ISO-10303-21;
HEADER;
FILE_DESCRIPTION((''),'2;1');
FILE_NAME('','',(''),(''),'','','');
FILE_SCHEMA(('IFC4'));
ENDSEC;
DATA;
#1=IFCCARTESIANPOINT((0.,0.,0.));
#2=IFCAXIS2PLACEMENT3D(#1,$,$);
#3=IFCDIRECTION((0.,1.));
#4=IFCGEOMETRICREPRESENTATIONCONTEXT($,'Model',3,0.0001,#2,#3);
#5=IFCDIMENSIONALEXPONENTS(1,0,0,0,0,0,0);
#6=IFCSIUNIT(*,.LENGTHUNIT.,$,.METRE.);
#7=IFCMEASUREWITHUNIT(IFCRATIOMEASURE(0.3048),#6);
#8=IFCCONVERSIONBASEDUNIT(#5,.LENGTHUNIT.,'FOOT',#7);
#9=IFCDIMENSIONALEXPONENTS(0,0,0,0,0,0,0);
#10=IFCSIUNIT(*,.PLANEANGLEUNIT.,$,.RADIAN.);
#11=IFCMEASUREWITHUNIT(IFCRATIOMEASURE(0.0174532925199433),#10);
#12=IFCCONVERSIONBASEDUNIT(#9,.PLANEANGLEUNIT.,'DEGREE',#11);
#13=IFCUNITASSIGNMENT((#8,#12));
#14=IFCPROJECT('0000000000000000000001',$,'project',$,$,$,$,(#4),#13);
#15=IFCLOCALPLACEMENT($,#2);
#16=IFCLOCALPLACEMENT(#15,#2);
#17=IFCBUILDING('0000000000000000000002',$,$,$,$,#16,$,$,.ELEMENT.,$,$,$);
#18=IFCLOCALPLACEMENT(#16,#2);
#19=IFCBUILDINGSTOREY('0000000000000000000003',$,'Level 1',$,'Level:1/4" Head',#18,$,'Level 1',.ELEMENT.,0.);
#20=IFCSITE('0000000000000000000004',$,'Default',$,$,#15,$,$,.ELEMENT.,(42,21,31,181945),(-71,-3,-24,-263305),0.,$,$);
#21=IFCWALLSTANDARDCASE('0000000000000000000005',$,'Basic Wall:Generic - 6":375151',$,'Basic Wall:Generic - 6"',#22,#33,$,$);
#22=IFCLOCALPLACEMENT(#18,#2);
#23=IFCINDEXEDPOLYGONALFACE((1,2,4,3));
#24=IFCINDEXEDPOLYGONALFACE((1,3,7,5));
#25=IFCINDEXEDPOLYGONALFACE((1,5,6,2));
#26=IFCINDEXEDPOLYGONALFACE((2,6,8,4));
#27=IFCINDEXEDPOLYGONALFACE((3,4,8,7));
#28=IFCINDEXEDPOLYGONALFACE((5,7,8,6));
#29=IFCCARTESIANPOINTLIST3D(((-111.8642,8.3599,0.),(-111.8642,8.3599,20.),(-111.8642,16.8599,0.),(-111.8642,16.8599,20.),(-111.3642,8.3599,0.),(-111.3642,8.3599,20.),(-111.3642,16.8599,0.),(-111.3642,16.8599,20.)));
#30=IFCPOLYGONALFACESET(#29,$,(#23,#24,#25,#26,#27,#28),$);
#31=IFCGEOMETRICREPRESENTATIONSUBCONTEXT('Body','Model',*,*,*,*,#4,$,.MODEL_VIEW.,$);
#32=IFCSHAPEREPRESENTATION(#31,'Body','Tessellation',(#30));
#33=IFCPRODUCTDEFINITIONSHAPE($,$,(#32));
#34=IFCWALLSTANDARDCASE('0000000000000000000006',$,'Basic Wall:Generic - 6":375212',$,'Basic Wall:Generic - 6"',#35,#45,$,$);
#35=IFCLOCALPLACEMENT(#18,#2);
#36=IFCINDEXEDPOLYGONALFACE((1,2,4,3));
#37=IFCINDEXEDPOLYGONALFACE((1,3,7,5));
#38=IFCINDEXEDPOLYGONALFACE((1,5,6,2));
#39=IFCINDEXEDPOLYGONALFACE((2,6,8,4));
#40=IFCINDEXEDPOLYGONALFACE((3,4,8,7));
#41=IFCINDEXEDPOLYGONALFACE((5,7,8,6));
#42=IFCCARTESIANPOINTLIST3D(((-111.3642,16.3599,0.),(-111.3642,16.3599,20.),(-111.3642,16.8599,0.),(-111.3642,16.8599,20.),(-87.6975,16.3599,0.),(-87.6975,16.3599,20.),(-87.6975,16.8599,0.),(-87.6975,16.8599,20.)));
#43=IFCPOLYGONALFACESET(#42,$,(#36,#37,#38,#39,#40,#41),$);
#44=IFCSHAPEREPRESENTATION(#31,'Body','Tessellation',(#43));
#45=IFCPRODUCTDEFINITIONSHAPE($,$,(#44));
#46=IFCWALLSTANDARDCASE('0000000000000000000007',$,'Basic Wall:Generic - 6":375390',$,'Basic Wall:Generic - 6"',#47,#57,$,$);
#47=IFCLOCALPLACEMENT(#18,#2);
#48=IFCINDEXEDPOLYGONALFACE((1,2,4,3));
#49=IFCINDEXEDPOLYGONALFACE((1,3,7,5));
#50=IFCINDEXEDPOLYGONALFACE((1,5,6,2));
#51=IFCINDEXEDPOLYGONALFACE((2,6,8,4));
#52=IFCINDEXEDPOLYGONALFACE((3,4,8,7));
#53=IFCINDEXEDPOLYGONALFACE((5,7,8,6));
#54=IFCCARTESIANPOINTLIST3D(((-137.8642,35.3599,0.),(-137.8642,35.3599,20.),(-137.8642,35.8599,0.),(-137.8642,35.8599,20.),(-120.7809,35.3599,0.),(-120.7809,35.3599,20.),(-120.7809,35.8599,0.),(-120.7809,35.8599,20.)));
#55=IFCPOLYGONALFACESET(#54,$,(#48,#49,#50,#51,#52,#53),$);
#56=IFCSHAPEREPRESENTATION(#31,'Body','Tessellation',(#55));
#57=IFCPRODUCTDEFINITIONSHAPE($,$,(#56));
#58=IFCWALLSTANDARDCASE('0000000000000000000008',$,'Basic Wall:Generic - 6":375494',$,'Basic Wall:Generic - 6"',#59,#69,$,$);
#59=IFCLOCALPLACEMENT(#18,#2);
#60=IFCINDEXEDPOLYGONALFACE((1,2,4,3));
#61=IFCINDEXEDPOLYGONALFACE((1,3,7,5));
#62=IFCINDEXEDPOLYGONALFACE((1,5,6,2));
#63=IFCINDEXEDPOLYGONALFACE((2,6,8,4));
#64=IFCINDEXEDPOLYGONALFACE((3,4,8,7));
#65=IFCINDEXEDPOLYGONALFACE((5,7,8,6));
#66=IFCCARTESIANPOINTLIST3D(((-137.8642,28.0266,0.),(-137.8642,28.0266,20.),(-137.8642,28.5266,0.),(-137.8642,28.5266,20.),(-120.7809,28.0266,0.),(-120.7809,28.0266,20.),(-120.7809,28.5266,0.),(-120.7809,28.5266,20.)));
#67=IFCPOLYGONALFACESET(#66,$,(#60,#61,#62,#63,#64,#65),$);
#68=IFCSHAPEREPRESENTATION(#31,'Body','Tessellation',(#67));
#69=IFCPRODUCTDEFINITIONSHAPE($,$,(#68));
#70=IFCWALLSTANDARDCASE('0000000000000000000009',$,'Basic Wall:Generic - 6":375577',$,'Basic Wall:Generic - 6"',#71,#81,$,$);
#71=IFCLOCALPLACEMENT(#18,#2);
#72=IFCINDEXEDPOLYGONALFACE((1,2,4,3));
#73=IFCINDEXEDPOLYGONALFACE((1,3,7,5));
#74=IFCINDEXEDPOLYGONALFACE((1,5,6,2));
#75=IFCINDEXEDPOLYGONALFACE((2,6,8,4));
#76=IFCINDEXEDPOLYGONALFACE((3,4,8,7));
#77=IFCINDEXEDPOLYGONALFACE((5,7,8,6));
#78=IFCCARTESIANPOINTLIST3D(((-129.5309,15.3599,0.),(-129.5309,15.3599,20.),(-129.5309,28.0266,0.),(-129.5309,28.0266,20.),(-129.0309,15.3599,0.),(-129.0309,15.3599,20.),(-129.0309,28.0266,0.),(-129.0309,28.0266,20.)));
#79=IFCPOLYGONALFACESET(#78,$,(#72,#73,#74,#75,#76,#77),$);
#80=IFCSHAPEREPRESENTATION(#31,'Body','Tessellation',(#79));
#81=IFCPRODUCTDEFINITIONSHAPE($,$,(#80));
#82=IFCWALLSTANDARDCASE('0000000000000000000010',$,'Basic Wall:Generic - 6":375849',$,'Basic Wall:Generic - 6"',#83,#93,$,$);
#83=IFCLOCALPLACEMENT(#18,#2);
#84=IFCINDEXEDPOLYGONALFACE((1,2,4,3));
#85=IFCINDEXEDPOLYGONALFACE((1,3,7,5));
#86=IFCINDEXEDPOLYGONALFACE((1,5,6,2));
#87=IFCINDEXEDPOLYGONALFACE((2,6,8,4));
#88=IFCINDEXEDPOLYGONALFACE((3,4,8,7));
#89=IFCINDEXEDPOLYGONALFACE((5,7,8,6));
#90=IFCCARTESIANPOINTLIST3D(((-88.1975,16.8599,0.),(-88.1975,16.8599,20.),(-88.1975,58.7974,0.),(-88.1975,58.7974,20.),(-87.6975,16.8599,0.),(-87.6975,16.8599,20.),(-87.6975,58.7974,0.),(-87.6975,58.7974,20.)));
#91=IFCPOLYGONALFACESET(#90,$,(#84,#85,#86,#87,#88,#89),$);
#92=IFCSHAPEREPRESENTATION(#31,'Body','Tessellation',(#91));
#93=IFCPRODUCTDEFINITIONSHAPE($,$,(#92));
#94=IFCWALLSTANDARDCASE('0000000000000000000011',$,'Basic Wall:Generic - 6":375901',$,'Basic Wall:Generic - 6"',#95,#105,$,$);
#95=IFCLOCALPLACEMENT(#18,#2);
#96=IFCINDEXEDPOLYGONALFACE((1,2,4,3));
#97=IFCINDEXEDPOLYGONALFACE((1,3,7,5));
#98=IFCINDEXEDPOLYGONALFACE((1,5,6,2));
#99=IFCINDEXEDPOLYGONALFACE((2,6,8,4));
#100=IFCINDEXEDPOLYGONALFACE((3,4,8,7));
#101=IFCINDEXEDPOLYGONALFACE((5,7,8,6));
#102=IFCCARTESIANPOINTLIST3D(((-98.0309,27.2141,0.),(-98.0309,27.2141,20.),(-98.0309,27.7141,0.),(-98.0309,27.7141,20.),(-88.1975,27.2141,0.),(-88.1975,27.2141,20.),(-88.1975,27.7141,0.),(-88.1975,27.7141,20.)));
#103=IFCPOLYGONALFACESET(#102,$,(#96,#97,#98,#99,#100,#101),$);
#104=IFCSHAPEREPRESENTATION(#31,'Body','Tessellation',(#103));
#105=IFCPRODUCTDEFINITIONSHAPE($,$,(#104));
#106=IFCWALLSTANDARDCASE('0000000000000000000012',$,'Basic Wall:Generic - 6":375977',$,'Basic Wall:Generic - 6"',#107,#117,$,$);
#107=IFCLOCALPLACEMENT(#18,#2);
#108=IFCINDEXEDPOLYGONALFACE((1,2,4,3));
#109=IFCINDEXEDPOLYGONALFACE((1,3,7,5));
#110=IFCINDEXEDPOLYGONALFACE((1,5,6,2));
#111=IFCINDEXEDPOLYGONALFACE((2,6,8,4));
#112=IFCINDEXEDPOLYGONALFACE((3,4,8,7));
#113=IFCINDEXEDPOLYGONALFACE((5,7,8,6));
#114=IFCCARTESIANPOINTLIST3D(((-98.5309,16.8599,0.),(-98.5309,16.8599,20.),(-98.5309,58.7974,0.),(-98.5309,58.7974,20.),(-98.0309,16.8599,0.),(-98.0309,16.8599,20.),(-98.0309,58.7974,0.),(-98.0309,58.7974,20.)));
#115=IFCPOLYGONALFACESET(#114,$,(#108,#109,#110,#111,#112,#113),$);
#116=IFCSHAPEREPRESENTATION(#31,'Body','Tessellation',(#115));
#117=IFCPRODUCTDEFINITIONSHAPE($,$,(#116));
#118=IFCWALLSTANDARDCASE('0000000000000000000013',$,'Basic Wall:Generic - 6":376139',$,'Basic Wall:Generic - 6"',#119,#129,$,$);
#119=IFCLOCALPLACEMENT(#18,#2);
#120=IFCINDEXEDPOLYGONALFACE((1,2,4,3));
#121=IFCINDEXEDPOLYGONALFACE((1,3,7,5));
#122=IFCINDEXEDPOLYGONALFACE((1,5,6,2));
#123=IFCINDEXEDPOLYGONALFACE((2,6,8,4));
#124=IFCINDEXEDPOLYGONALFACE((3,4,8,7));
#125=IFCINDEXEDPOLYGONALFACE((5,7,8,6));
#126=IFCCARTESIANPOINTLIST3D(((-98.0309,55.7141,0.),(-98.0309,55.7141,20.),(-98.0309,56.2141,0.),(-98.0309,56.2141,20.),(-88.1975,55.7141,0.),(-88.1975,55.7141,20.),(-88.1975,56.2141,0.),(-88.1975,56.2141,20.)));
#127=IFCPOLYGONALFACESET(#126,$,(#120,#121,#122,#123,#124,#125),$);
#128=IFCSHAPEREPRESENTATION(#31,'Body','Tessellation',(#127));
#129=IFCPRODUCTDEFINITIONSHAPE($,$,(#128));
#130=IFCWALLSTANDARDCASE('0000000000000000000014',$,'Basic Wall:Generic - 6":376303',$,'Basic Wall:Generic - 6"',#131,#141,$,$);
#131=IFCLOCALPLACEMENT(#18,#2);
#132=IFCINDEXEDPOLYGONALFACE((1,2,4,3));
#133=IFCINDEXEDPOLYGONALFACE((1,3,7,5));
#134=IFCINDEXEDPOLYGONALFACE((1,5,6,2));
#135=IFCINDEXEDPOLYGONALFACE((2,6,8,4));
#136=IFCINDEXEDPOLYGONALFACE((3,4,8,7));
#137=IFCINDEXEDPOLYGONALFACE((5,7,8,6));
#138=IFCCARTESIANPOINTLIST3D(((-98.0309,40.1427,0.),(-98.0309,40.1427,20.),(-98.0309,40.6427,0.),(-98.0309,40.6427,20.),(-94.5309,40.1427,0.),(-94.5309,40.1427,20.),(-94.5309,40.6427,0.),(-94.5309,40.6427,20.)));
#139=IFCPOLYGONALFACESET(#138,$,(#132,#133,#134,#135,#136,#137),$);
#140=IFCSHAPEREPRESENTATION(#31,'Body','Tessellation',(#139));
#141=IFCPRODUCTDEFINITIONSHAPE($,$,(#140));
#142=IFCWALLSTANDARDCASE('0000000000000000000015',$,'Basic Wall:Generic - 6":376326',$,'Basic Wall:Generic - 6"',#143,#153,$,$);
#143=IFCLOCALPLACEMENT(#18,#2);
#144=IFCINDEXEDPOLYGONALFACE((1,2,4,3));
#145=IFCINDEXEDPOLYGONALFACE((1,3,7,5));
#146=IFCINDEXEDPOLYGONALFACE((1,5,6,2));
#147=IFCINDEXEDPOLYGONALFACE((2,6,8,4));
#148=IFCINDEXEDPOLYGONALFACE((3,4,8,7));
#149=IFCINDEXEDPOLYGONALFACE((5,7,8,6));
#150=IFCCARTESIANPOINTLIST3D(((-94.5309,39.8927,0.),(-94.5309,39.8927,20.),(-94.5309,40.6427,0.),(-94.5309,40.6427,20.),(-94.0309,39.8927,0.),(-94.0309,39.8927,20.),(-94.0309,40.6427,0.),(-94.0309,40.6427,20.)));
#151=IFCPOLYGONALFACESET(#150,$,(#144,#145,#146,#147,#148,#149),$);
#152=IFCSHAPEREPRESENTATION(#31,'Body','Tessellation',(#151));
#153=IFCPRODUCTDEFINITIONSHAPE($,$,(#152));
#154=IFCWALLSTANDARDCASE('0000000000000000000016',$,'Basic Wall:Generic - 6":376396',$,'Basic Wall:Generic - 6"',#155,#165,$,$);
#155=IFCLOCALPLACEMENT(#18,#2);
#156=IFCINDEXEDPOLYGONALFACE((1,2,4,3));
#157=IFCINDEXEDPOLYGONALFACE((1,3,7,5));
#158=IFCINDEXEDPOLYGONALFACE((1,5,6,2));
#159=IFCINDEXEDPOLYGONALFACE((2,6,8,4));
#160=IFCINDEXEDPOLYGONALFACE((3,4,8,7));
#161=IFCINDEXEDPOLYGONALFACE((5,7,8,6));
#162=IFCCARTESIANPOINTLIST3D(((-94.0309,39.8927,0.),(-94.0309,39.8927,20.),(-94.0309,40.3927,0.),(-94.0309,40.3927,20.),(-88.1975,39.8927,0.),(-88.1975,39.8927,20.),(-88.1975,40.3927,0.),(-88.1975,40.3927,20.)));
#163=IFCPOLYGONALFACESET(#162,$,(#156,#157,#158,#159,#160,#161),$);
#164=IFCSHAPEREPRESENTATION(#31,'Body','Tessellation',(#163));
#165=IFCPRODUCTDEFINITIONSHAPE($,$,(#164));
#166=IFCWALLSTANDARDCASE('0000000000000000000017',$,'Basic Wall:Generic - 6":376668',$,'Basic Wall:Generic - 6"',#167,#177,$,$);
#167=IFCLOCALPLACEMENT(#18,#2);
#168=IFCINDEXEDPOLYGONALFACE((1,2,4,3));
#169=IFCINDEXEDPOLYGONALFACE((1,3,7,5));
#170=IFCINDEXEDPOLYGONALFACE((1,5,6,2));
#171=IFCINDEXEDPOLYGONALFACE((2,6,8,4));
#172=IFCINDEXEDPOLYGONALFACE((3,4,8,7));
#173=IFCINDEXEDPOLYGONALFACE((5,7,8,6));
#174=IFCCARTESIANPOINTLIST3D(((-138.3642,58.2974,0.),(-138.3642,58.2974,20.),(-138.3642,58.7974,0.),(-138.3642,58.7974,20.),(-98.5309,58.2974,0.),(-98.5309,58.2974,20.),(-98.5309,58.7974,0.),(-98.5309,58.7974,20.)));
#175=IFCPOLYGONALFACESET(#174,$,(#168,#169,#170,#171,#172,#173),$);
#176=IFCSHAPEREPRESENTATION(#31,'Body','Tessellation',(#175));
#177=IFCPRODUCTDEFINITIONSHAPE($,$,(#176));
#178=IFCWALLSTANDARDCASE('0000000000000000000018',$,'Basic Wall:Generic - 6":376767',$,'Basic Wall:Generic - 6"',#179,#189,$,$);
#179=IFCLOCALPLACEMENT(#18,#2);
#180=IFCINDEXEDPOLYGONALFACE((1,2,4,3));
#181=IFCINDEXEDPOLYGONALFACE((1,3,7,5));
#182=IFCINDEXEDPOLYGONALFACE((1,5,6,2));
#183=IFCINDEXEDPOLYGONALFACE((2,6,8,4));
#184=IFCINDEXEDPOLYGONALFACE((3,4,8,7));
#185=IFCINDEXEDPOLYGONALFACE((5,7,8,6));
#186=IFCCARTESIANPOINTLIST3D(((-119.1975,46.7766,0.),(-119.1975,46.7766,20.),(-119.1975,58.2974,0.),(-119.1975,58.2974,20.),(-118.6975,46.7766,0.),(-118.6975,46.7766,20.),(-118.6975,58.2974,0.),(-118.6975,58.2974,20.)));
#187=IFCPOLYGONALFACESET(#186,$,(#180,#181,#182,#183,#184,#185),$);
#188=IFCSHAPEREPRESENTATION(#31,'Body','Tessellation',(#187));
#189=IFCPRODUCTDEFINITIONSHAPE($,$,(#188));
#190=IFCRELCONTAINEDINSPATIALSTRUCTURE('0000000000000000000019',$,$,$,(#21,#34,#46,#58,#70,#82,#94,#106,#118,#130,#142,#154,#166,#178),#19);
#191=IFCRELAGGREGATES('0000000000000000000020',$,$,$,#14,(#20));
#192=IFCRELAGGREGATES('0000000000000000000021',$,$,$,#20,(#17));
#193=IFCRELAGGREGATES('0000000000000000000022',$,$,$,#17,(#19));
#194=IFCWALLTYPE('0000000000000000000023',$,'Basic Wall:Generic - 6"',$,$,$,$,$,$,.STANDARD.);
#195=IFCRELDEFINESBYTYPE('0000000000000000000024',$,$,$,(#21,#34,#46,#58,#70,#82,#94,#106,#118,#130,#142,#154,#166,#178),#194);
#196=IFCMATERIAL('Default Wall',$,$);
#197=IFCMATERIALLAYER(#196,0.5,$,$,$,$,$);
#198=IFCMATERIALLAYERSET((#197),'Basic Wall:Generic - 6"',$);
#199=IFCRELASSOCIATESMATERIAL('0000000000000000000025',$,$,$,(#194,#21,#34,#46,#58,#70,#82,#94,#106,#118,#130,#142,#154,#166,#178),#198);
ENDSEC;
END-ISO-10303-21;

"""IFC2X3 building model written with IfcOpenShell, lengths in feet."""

from ifc_helpers import new_model, entity, si_unit, converted_unit, direction, frame, frame_2d, origin, place, context, subcontext, project, spatial, rectangle, extrude, material, layer, layer_set, layer_usage, type_object, element, save


model = new_model("IFC2X3")

# Units and contexts
model_context = context("Model", 3, precision=0.0001, world=origin(), true_north=direction((0.0, 1.0)))
body_context = subcontext(model_context, "Body", "Model", "MODEL_VIEW")
ifc_project = project(units=[converted_unit("LENGTHUNIT", "FOOT", entity("IfcRatioMeasure", 0.3048), si_unit("LENGTHUNIT", "METRE"), dimensions=[1, 0, 0, 0, 0, 0, 0]), converted_unit("PLANEANGLEUNIT", "DEGREE", entity("IfcRatioMeasure", 0.0174532925199433), si_unit("PLANEANGLEUNIT", "RADIAN"), dimensions=[0, 0, 0, 0, 0, 0, 0])], contexts=[model_context])

# Site, building, storey
site_placement = place(None, origin())
site = spatial("IfcSite", under=ifc_project, at=site_placement, Name="Default", CompositionType="ELEMENT", RefLatitude=(42, 21, 31, 181945), RefLongitude=(-71, -3, -24, -263305), RefElevation=0.0)
building_placement = place(site_placement, origin())
building = spatial("IfcBuilding", under=site, at=building_placement, CompositionType="ELEMENT")
storey_placement = place(building_placement, origin())
storey = spatial("IfcBuildingStorey", under=building, at=storey_placement, Name="Level 1", ObjectType="Level:1/4\" Head", LongName="Level 1", CompositionType="ELEMENT", Elevation=0.0)

# Walls
ifc_material = material(Name="Default Wall")
ifc_layer_1 = layer(ifc_material, 0.5)
ifc_layer_set_1 = layer_set([ifc_layer_1], Name="Basic Wall:Generic - 6\"")
wall_type_1 = type_object("IfcWallType", Name="Basic Wall:Generic - 6\"", PredefinedType="STANDARD", material=ifc_layer_set_1)
ifc_layer_usage_1 = layer_usage(ifc_layer_set_1, "AXIS2", "NEGATIVE", 0.25)
wall_1_placement = place(storey_placement, frame((-111.6142, 8.3599, 0.0), z_axis=(0.0, 0.0, 1.0), x_axis=(0.0, 1.0, 0.0)))
element("IfcWallStandardCase", 1, at=wall_1_placement, inside=storey, type_object=wall_type_1, material=ifc_layer_usage_1, Name="Basic Wall:Generic - 6\":375151", ObjectType="Basic Wall:Generic - 6\"", context=body_context, shape_type="SweptSolid", body=[
    extrude(rectangle(XDim=8.5, YDim=0.5, at=frame_2d((4.25, 0.0), x_axis=(-1.0, 0.0))), origin(), (0.0, 0.0, 1.0), 20.0),
])
ifc_layer_usage_2 = layer_usage(ifc_layer_set_1, "AXIS2", "NEGATIVE", 0.25)
wall_2_placement = place(storey_placement, frame((-111.3642, 16.6099, 0.0)))
element("IfcWallStandardCase", 2, at=wall_2_placement, inside=storey, type_object=wall_type_1, material=ifc_layer_usage_2, Name="Basic Wall:Generic - 6\":375212", ObjectType="Basic Wall:Generic - 6\"", context=body_context, shape_type="SweptSolid", body=[
    extrude(rectangle(XDim=23.6667, YDim=0.5, at=frame_2d((11.8333, 0.0), x_axis=(-1.0, 0.0))), origin(), (0.0, 0.0, 1.0), 20.0),
])
ifc_layer_usage_3 = layer_usage(ifc_layer_set_1, "AXIS2", "NEGATIVE", 0.25)
wall_3_placement = place(storey_placement, frame((-120.7809, 35.6099, 0.0), z_axis=(0.0, 0.0, 1.0), x_axis=(-1.0, 0.0, 0.0)))
element("IfcWallStandardCase", 3, at=wall_3_placement, inside=storey, type_object=wall_type_1, material=ifc_layer_usage_3, Name="Basic Wall:Generic - 6\":375390", ObjectType="Basic Wall:Generic - 6\"", context=body_context, shape_type="SweptSolid", body=[
    extrude(rectangle(XDim=17.0833, YDim=0.5, at=frame_2d((8.5417, 0.0), x_axis=(-1.0, 0.0))), origin(), (0.0, 0.0, 1.0), 20.0),
])
ifc_layer_usage_4 = layer_usage(ifc_layer_set_1, "AXIS2", "NEGATIVE", 0.25)
wall_4_placement = place(storey_placement, frame((-120.7809, 28.2766, 0.0), z_axis=(0.0, 0.0, 1.0), x_axis=(-1.0, 0.0, 0.0)))
element("IfcWallStandardCase", 4, at=wall_4_placement, inside=storey, type_object=wall_type_1, material=ifc_layer_usage_4, Name="Basic Wall:Generic - 6\":375494", ObjectType="Basic Wall:Generic - 6\"", context=body_context, shape_type="SweptSolid", body=[
    extrude(rectangle(XDim=17.0833, YDim=0.5, at=frame_2d((8.5417, 0.0), x_axis=(-1.0, 0.0))), origin(), (0.0, 0.0, 1.0), 20.0),
])
ifc_layer_usage_5 = layer_usage(ifc_layer_set_1, "AXIS2", "NEGATIVE", 0.25)
wall_5_placement = place(storey_placement, frame((-129.2809, 15.3599, 0.0), z_axis=(0.0, 0.0, 1.0), x_axis=(0.0, 1.0, 0.0)))
element("IfcWallStandardCase", 5, at=wall_5_placement, inside=storey, type_object=wall_type_1, material=ifc_layer_usage_5, Name="Basic Wall:Generic - 6\":375577", ObjectType="Basic Wall:Generic - 6\"", context=body_context, shape_type="SweptSolid", body=[
    extrude(rectangle(XDim=12.6667, YDim=0.5, at=frame_2d((6.3333, 0.0), x_axis=(-1.0, 0.0))), origin(), (0.0, 0.0, 1.0), 20.0),
])
ifc_layer_usage_6 = layer_usage(ifc_layer_set_1, "AXIS2", "NEGATIVE", 0.25)
wall_6_placement = place(storey_placement, frame((-87.9475, 16.8599, 0.0), z_axis=(0.0, 0.0, 1.0), x_axis=(0.0, 1.0, 0.0)))
element("IfcWallStandardCase", 6, at=wall_6_placement, inside=storey, type_object=wall_type_1, material=ifc_layer_usage_6, Name="Basic Wall:Generic - 6\":375849", ObjectType="Basic Wall:Generic - 6\"", context=body_context, shape_type="SweptSolid", body=[
    extrude(rectangle(XDim=41.9375, YDim=0.5, at=frame_2d((20.9688, 0.0), x_axis=(-1.0, 0.0))), origin(), (0.0, 0.0, 1.0), 20.0),
])
ifc_layer_usage_7 = layer_usage(ifc_layer_set_1, "AXIS2", "NEGATIVE", 0.25)
wall_7_placement = place(storey_placement, frame((-88.1975, 27.4641, 0.0), z_axis=(0.0, 0.0, 1.0), x_axis=(-1.0, 0.0, 0.0)))
element("IfcWallStandardCase", 7, at=wall_7_placement, inside=storey, type_object=wall_type_1, material=ifc_layer_usage_7, Name="Basic Wall:Generic - 6\":375901", ObjectType="Basic Wall:Generic - 6\"", context=body_context, shape_type="SweptSolid", body=[
    extrude(rectangle(XDim=9.8333, YDim=0.5, at=frame_2d((4.9167, 0.0), x_axis=(-1.0, 0.0))), origin(), (0.0, 0.0, 1.0), 20.0),
])
ifc_layer_usage_8 = layer_usage(ifc_layer_set_1, "AXIS2", "NEGATIVE", 0.25)
wall_8_placement = place(storey_placement, frame((-98.2809, 58.7974, 0.0), z_axis=(0.0, 0.0, 1.0), x_axis=(0.0, -1.0, 0.0)))
element("IfcWallStandardCase", 8, at=wall_8_placement, inside=storey, type_object=wall_type_1, material=ifc_layer_usage_8, Name="Basic Wall:Generic - 6\":375977", ObjectType="Basic Wall:Generic - 6\"", context=body_context, shape_type="SweptSolid", body=[
    extrude(rectangle(XDim=41.9375, YDim=0.5, at=frame_2d((20.9688, 0.0), x_axis=(-1.0, 0.0))), origin(), (0.0, 0.0, 1.0), 20.0),
])
ifc_layer_usage_9 = layer_usage(ifc_layer_set_1, "AXIS2", "NEGATIVE", 0.25)
wall_9_placement = place(storey_placement, frame((-88.1975, 55.9641, 0.0), z_axis=(0.0, 0.0, 1.0), x_axis=(-1.0, 0.0, 0.0)))
element("IfcWallStandardCase", 9, at=wall_9_placement, inside=storey, type_object=wall_type_1, material=ifc_layer_usage_9, Name="Basic Wall:Generic - 6\":376139", ObjectType="Basic Wall:Generic - 6\"", context=body_context, shape_type="SweptSolid", body=[
    extrude(rectangle(XDim=9.8333, YDim=0.5, at=frame_2d((4.9167, 0.0), x_axis=(-1.0, 0.0))), origin(), (0.0, 0.0, 1.0), 20.0),
])
ifc_layer_usage_10 = layer_usage(ifc_layer_set_1, "AXIS2", "NEGATIVE", 0.25)
wall_10_placement = place(storey_placement, frame((-98.0309, 40.3927, 0.0)))
element("IfcWallStandardCase", 10, at=wall_10_placement, inside=storey, type_object=wall_type_1, material=ifc_layer_usage_10, Name="Basic Wall:Generic - 6\":376303", ObjectType="Basic Wall:Generic - 6\"", context=body_context, shape_type="SweptSolid", body=[
    extrude(rectangle(XDim=3.5, YDim=0.5, at=frame_2d((1.75, 0.0), x_axis=(-1.0, 0.0))), origin(), (0.0, 0.0, 1.0), 20.0),
])
ifc_layer_usage_11 = layer_usage(ifc_layer_set_1, "AXIS2", "NEGATIVE", 0.25)
wall_11_placement = place(storey_placement, frame((-94.2809, 40.6427, 0.0), z_axis=(0.0, 0.0, 1.0), x_axis=(0.0, -1.0, 0.0)))
element("IfcWallStandardCase", 11, at=wall_11_placement, inside=storey, type_object=wall_type_1, material=ifc_layer_usage_11, Name="Basic Wall:Generic - 6\":376326", ObjectType="Basic Wall:Generic - 6\"", context=body_context, shape_type="SweptSolid", body=[
    extrude(rectangle(XDim=0.75, YDim=0.5, at=frame_2d((0.375, 0.0), x_axis=(-1.0, 0.0))), origin(), (0.0, 0.0, 1.0), 20.0),
])
ifc_layer_usage_12 = layer_usage(ifc_layer_set_1, "AXIS2", "NEGATIVE", 0.25)
wall_12_placement = place(storey_placement, frame((-94.0309, 40.1427, 0.0)))
element("IfcWallStandardCase", 12, at=wall_12_placement, inside=storey, type_object=wall_type_1, material=ifc_layer_usage_12, Name="Basic Wall:Generic - 6\":376396", ObjectType="Basic Wall:Generic - 6\"", context=body_context, shape_type="SweptSolid", body=[
    extrude(rectangle(XDim=5.8333, YDim=0.5, at=frame_2d((2.9167, 0.0), x_axis=(-1.0, 0.0))), origin(), (0.0, 0.0, 1.0), 20.0),
])
ifc_layer_usage_13 = layer_usage(ifc_layer_set_1, "AXIS2", "NEGATIVE", 0.25)
wall_13_placement = place(storey_placement, frame((-98.5309, 58.5474, 0.0), z_axis=(0.0, 0.0, 1.0), x_axis=(-1.0, 0.0, 0.0)))
element("IfcWallStandardCase", 13, at=wall_13_placement, inside=storey, type_object=wall_type_1, material=ifc_layer_usage_13, Name="Basic Wall:Generic - 6\":376668", ObjectType="Basic Wall:Generic - 6\"", context=body_context, shape_type="SweptSolid", body=[
    extrude(rectangle(XDim=39.8333, YDim=0.5, at=frame_2d((19.9167, 0.0), x_axis=(-1.0, 0.0))), origin(), (0.0, 0.0, 1.0), 20.0),
])
ifc_layer_usage_14 = layer_usage(ifc_layer_set_1, "AXIS2", "NEGATIVE", 0.25)
wall_14_placement = place(storey_placement, frame((-118.9475, 58.2974, 0.0), z_axis=(0.0, 0.0, 1.0), x_axis=(0.0, -1.0, 0.0)))
element("IfcWallStandardCase", 14, at=wall_14_placement, inside=storey, type_object=wall_type_1, material=ifc_layer_usage_14, Name="Basic Wall:Generic - 6\":376767", ObjectType="Basic Wall:Generic - 6\"", context=body_context, shape_type="SweptSolid", body=[
    extrude(rectangle(XDim=11.5208, YDim=0.5, at=frame_2d((5.7604, 0.0), x_axis=(-1.0, 0.0))), origin(), (0.0, 0.0, 1.0), 20.0),
])

save(model, "model.ifc")
